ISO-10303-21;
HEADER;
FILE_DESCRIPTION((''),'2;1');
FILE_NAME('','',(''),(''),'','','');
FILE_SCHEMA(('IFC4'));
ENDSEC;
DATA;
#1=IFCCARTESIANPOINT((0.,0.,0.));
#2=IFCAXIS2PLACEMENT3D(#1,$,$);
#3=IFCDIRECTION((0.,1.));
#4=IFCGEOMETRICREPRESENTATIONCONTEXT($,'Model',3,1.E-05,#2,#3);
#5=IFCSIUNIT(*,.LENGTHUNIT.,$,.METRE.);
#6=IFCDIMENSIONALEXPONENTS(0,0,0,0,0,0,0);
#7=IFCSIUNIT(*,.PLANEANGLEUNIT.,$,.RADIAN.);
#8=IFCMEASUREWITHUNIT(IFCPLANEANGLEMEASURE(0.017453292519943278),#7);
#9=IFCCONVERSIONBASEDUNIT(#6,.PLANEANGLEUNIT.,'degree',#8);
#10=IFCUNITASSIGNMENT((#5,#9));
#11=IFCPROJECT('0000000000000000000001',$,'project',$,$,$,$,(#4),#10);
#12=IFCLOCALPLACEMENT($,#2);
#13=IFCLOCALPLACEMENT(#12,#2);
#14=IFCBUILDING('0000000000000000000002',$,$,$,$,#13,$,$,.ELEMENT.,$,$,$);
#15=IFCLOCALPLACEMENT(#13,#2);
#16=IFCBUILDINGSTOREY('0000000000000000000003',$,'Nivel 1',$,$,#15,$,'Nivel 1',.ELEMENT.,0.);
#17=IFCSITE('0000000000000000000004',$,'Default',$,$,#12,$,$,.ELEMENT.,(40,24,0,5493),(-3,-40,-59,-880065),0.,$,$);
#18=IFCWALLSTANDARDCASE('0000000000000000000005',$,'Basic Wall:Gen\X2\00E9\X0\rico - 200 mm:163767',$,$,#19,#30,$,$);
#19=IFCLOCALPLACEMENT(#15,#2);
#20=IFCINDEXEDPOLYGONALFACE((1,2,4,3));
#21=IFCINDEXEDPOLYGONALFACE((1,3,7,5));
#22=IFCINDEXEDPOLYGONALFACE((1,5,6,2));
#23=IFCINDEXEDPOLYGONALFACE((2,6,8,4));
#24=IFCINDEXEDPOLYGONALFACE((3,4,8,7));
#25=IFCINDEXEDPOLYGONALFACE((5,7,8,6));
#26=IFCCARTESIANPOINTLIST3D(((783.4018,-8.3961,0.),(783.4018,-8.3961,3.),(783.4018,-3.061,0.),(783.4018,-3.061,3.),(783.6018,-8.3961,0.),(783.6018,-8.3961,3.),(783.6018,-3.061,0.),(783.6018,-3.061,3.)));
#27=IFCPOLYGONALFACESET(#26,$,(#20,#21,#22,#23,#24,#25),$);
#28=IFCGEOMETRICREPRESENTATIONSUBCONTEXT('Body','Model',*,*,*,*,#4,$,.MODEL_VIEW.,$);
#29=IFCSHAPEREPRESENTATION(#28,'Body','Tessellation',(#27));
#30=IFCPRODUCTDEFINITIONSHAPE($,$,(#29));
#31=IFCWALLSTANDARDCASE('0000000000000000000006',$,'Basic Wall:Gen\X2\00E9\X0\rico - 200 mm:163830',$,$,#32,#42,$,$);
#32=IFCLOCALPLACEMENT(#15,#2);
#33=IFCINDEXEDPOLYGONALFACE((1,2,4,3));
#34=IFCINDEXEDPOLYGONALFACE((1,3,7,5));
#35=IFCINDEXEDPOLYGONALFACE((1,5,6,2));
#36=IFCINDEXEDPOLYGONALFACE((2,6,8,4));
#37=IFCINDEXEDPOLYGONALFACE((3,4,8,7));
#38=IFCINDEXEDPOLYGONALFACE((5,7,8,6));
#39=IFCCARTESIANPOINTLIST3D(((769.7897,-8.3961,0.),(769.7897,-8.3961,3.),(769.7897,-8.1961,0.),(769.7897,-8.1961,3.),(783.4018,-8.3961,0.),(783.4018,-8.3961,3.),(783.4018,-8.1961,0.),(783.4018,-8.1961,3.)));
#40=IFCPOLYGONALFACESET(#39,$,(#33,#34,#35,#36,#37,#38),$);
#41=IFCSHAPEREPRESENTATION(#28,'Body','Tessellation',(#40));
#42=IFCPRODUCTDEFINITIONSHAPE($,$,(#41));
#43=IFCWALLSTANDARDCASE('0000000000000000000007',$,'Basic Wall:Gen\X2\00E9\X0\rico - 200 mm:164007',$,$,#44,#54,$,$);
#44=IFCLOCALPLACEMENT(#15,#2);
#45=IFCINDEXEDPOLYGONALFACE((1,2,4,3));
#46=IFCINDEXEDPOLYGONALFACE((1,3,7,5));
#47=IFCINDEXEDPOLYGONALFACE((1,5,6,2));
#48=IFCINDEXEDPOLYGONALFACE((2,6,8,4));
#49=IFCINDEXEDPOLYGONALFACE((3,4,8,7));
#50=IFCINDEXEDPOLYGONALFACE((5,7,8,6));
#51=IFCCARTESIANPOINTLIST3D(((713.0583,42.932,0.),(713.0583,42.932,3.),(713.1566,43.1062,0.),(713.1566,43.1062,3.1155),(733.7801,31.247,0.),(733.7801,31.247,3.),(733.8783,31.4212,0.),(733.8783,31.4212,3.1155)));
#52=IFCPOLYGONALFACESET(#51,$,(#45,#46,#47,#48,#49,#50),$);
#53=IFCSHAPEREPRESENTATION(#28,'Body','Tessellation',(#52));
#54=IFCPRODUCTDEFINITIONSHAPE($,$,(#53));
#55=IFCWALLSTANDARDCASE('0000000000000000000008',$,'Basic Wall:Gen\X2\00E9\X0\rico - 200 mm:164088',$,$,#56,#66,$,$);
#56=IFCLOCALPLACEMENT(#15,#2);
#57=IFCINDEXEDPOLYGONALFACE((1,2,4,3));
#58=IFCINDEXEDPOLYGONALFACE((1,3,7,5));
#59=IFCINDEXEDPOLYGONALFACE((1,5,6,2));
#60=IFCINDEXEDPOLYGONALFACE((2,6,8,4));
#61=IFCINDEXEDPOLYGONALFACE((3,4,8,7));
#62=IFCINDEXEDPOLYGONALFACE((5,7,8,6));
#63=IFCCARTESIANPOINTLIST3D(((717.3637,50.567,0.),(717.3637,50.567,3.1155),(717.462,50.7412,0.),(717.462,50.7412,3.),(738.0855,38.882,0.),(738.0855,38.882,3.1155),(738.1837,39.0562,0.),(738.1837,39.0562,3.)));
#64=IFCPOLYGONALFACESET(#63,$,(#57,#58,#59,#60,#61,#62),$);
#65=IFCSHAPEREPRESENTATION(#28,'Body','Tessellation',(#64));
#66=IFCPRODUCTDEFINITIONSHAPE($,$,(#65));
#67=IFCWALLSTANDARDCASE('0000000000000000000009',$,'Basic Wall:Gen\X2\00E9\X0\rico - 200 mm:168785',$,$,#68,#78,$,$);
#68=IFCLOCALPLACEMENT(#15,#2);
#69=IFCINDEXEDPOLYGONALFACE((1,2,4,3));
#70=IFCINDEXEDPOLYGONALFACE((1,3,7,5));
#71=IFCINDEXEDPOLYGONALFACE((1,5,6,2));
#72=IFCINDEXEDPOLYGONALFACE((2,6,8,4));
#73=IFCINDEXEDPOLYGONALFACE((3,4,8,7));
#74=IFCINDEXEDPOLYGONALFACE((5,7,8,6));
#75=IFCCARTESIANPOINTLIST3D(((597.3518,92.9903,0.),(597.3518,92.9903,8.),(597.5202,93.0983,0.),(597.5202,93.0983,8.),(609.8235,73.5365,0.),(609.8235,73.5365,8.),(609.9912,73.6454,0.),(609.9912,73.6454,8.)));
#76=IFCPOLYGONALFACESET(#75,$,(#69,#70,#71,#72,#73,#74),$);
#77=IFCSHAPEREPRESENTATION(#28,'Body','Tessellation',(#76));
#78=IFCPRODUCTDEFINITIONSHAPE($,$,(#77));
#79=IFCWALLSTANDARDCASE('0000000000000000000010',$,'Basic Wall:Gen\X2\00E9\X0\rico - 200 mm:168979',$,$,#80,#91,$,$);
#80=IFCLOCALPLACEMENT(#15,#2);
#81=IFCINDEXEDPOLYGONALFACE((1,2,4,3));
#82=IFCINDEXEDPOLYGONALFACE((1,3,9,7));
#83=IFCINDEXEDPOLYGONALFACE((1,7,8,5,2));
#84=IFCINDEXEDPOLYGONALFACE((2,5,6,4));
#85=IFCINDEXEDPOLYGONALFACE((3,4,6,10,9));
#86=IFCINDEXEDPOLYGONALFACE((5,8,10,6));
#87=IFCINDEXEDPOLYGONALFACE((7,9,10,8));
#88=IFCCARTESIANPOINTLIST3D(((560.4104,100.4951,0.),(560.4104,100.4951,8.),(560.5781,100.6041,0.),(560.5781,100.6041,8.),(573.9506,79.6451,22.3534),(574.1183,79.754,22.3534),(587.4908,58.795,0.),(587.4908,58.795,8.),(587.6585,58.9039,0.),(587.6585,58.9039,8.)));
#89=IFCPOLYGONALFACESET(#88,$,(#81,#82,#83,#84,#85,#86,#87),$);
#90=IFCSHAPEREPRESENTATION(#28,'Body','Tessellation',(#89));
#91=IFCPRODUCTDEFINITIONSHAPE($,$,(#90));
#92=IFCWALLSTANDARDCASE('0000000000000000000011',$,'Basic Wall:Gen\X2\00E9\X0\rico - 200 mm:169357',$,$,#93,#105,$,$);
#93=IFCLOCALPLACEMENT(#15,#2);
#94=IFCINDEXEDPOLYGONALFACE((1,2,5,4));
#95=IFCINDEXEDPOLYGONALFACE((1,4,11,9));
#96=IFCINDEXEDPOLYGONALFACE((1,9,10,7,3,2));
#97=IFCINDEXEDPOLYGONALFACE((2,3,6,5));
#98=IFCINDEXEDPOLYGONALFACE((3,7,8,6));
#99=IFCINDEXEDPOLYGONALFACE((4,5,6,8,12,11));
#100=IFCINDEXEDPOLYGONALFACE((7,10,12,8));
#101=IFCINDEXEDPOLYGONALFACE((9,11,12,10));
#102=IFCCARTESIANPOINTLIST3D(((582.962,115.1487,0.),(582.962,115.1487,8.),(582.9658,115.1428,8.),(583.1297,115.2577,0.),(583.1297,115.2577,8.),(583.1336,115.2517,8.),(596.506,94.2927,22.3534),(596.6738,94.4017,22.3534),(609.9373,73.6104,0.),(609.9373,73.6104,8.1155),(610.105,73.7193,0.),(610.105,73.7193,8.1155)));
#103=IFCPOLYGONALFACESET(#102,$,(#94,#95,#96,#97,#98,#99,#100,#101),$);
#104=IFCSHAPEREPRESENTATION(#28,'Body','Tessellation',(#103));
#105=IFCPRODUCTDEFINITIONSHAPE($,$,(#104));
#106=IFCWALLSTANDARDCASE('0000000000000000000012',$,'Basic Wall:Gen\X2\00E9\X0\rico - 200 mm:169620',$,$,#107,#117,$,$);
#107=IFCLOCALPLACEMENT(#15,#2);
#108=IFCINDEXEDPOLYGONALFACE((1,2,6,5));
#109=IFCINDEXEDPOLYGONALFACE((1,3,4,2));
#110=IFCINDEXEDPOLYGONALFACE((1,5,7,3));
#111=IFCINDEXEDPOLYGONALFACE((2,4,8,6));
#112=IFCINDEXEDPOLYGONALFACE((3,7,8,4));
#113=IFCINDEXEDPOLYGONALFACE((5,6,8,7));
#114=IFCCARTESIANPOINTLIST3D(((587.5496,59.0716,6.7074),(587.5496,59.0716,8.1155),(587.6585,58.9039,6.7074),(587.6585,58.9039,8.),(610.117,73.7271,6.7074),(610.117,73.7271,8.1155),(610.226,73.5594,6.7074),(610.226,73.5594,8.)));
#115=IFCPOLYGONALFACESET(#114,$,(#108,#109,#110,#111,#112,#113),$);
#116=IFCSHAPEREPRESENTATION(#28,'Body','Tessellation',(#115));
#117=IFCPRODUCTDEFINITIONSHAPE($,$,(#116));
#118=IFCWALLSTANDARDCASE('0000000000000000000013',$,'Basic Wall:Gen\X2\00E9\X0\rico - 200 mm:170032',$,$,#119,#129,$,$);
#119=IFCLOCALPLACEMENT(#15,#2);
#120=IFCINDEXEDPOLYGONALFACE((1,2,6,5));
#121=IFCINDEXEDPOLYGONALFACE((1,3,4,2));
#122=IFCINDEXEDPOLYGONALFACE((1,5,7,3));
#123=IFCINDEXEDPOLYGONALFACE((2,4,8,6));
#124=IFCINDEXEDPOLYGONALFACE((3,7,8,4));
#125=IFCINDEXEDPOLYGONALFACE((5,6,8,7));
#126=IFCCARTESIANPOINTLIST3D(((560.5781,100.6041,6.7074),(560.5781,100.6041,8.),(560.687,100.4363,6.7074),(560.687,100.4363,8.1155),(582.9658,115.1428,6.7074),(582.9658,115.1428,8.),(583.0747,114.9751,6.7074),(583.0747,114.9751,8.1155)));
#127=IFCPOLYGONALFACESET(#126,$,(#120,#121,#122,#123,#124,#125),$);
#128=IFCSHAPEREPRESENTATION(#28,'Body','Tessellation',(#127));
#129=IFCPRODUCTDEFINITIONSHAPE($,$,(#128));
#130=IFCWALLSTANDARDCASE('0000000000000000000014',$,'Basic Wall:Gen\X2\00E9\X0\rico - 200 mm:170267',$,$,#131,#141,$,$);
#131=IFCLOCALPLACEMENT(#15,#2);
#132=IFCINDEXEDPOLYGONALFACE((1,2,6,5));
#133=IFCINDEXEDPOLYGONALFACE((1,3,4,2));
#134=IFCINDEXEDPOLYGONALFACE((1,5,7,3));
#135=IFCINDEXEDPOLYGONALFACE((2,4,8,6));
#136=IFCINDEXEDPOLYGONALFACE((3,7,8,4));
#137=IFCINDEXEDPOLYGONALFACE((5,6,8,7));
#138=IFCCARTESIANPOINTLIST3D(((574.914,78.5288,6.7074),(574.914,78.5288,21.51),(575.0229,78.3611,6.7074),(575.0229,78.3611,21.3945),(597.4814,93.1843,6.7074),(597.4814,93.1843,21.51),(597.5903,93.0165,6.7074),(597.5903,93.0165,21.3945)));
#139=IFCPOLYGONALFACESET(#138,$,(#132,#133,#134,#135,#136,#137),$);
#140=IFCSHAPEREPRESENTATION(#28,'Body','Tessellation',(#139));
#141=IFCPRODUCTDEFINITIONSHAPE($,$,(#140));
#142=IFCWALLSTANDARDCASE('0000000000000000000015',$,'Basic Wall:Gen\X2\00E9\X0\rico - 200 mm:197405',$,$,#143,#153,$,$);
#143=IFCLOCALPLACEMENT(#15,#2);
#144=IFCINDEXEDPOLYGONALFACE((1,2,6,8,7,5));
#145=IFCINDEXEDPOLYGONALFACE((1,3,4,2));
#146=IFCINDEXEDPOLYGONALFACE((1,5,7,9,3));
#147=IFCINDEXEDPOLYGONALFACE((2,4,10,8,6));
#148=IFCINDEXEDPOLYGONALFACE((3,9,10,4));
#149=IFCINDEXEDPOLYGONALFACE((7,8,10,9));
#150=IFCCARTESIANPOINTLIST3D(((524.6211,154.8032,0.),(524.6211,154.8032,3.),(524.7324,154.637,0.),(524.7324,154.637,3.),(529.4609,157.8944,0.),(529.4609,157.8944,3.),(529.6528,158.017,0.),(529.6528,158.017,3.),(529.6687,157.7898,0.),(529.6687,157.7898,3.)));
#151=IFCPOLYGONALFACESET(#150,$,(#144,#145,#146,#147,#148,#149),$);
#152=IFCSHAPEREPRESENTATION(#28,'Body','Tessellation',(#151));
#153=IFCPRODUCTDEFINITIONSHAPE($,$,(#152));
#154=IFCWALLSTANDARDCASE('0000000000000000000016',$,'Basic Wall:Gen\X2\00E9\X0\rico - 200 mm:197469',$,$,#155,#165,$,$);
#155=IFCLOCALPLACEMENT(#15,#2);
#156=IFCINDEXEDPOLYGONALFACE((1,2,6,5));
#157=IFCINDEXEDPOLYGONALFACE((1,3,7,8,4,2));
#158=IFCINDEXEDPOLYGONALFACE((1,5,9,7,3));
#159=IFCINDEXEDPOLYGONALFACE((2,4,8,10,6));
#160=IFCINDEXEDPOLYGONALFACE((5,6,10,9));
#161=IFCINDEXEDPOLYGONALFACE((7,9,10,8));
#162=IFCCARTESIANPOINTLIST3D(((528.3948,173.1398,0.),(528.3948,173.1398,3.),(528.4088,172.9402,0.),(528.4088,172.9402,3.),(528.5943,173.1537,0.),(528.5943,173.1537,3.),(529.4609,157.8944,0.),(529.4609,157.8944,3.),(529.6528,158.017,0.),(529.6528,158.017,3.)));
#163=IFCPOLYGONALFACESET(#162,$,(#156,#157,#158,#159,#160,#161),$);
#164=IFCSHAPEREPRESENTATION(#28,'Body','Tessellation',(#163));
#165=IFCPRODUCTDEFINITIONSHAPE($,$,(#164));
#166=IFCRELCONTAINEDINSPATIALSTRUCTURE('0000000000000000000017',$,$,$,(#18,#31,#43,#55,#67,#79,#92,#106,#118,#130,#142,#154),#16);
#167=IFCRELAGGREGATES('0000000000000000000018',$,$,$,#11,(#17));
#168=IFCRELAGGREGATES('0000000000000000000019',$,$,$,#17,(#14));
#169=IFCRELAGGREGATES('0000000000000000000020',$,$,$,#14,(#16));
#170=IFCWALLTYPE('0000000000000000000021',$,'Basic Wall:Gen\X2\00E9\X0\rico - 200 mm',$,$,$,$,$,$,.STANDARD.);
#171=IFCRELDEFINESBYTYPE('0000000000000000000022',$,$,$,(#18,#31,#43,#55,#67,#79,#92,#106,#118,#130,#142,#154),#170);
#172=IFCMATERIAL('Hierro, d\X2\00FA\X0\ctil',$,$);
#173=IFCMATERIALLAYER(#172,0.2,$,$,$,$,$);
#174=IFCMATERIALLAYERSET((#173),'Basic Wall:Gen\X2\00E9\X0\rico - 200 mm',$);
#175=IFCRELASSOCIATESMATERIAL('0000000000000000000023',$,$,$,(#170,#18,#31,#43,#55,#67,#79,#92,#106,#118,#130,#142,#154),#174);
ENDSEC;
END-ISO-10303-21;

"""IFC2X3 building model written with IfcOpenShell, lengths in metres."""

from ifc_helpers import new_model, entity, si_unit, converted_unit, direction, frame, frame_2d, origin, place, context, subcontext, project, spatial, polyline, rectangle, outline, extrude, clip, bounded_halfspace, material, layer, layer_set, layer_usage, type_object, element, save


model = new_model("IFC2X3")

# Units and contexts
model_context = context("Model", 3, precision=1e-05, world=origin(), true_north=direction((0.0, 1.0)))
body_context = subcontext(model_context, "Body", "Model", "MODEL_VIEW")
ifc_project = project(units=[si_unit("LENGTHUNIT", "METRE"), converted_unit("PLANEANGLEUNIT", "degree", entity("IfcPlaneAngleMeasure", 0.017453292519943278), si_unit("PLANEANGLEUNIT", "RADIAN"), dimensions=[0, 0, 0, 0, 0, 0, 0])], contexts=[model_context])

# Site, building, storey
site_placement = place(None, origin())
site = spatial("IfcSite", under=ifc_project, at=site_placement, Name="Default", CompositionType="ELEMENT", RefLatitude=(40, 24, 0, 5493), RefLongitude=(-3, -40, -59, -880065), RefElevation=0.0)
building_placement = place(site_placement, origin())
building = spatial("IfcBuilding", under=site, at=building_placement, CompositionType="ELEMENT")
storey_placement = place(building_placement, origin())
storey = spatial("IfcBuildingStorey", under=building, at=storey_placement, Name="Nivel 1", LongName="Nivel 1", CompositionType="ELEMENT", Elevation=0.0)

# Walls
ifc_material_1 = material(Name="Hierro, dúctil")
ifc_layer_1 = layer(ifc_material_1, 0.2)
ifc_layer_set_1 = layer_set([ifc_layer_1], Name="Basic Wall:Genérico - 200 mm")
wall_type = type_object("IfcWallType", Name="Basic Wall:Genérico - 200 mm", PredefinedType="STANDARD", material=ifc_layer_set_1)
ifc_layer_usage_1 = layer_usage(ifc_layer_set_1, "AXIS2", "NEGATIVE", 0.1)
wall_1_placement = place(storey_placement, frame((783.5018, -3.061, 0.0), z_axis=(0.0, 0.0, 1.0), x_axis=(0.0, -1.0, 0.0)))
element("IfcWallStandardCase", 1, at=wall_1_placement, inside=storey, type_object=wall_type, material=ifc_layer_usage_1, Name="Basic Wall:Genérico - 200 mm:163767", context=body_context, shape_type="SweptSolid", body=[
    extrude(rectangle(XDim=5.3351, YDim=0.2, at=frame_2d((2.6675, 0.0), x_axis=(-1.0, 0.0))), origin(), (0.0, 0.0, 1.0), 3.0),
])
ifc_layer_usage_2 = layer_usage(ifc_layer_set_1, "AXIS2", "NEGATIVE", 0.1)
wall_2_placement = place(storey_placement, frame((783.4018, -8.2961, 0.0), z_axis=(0.0, 0.0, 1.0), x_axis=(-1.0, 0.0, 0.0)))
element("IfcWallStandardCase", 2, at=wall_2_placement, inside=storey, type_object=wall_type, material=ifc_layer_usage_2, Name="Basic Wall:Genérico - 200 mm:163830", context=body_context, shape_type="SweptSolid", body=[
    extrude(rectangle(XDim=13.6122, YDim=0.2, at=frame_2d((6.8061, 0.0), x_axis=(-1.0, 0.0))), origin(), (0.0, 0.0, 1.0), 3.0),
])
ifc_layer_usage_3 = layer_usage(ifc_layer_set_1, "AXIS2", "NEGATIVE", 0.1)
wall_3_placement = place(storey_placement, frame((713.1075, 43.0191, 0.0), z_axis=(0.0, 0.0, 1.0), x_axis=(0.871054, -0.491187, 0.0)))
element("IfcWallStandardCase", 3, at=wall_3_placement, inside=storey, type_object=wall_type, material=ifc_layer_usage_3, Name="Basic Wall:Genérico - 200 mm:164007", context=body_context, shape_type="Clipping", body=[
    clip(extrude(rectangle(XDim=23.7893, YDim=0.2, at=frame_2d((11.8946, 0.0), x_axis=(-1.0, 0.0))), origin(), (0.0, 0.0, 1.0), 3.1155), bounded_halfspace(frame((0.0, -0.1, 3.0), z_axis=(0.0, -0.5, 0.866025), x_axis=(1.0, 0.0, 0.0)), False, frame((0.0, -0.1, 3.0)), polyline([(0.0, 0.0), (23.7893, 0.0), (23.7893, 0.2), (23.5893, 0.2), (0.2, 0.2), (0.0, 0.2), (0.0, 0.0)]))),
])
ifc_layer_usage_4 = layer_usage(ifc_layer_set_1, "AXIS2", "NEGATIVE", 0.1)
wall_4_placement = place(storey_placement, frame((738.1346, 38.9691, 0.0), z_axis=(0.0, 0.0, 1.0), x_axis=(-0.871054, 0.491187, 0.0)))
element("IfcWallStandardCase", 4, at=wall_4_placement, inside=storey, type_object=wall_type, material=ifc_layer_usage_4, Name="Basic Wall:Genérico - 200 mm:164088", context=body_context, shape_type="Clipping", body=[
    clip(extrude(rectangle(XDim=23.7893, YDim=0.2, at=frame_2d((11.8946, 0.0), x_axis=(-1.0, 0.0))), origin(), (0.0, 0.0, 1.0), 3.1155), bounded_halfspace(frame((0.0, -0.1, 3.0), z_axis=(0.0, -0.5, 0.866025), x_axis=(1.0, 0.0, 0.0)), False, frame((0.0, -0.1, 3.0)), polyline([(0.0, 0.0), (23.7893, 0.0), (23.7893, 0.2), (23.5893, 0.2), (0.2, 0.2), (0.0, 0.2), (0.0, 0.0)]))),
])
ifc_layer_usage_5 = layer_usage(ifc_layer_set_1, "AXIS2", "NEGATIVE", 0.1)
wall_5_placement = place(storey_placement, frame((597.436, 93.0443, 0.0), z_axis=(0.0, 0.0, 1.0), x_axis=(0.539704, -0.841855, 0.0)))
element("IfcWallStandardCase", 5, at=wall_5_placement, inside=storey, type_object=wall_type, material=ifc_layer_usage_5, Name="Basic Wall:Genérico - 200 mm:168785", context=body_context, shape_type="SweptSolid", body=[
    extrude(outline(polyline([(23.1083, -0.1), (23.1072, 0.1), (0.0, 0.1), (0.0, -0.1), (23.1083, -0.1)])), origin(), (0.0, 0.0, 1.0), 8.0),
])
ifc_layer_usage_6 = layer_usage(ifc_layer_set_1, "AXIS2", "NEGATIVE", 0.1)
wall_6_placement = place(storey_placement, frame((560.4942, 100.5496, 0.0), z_axis=(0.0, 0.0, 1.0), x_axis=(0.544639, -0.838671, 0.0)))
element("IfcWallStandardCase", 6, at=wall_6_placement, inside=storey, type_object=wall_type, material=ifc_layer_usage_6, Name="Basic Wall:Genérico - 200 mm:168979", context=body_context, shape_type="Clipping", body=[
    clip(clip(extrude(rectangle(XDim=49.7218, YDim=0.2, at=frame_2d((24.8609, 0.0), x_axis=(-1.0, 0.0))), origin(), (0.0, 0.0, 1.0), 22.3534), bounded_halfspace(frame((0.0, -0.1, 8.0), z_axis=(-0.5, 0.0, 0.866025), x_axis=(0.0, -1.0, 0.0)), False, frame((0.0, -0.1, 8.0)), polyline([(0.0, 0.0), (24.8609, 0.0), (24.8609, 0.2), (0.2, 0.2), (0.0, 0.2), (0.0, 0.0)]))), bounded_halfspace(frame((24.8609, -0.1, 22.3534), z_axis=(0.5, 0.0, 0.866025), x_axis=(0.0, 1.0, 0.0)), False, frame((24.8609, -0.1, 22.3534)), polyline([(0.0, 0.0), (24.8609, 0.0), (24.8609, 0.2), (24.6609, 0.2), (1.6609, 0.2), (1.4609, 0.2), (0.0, 0.2), (0.0, 0.0)]))),
])
ifc_layer_usage_7 = layer_usage(ifc_layer_set_1, "AXIS2", "NEGATIVE", 0.1)
wall_7_placement = place(storey_placement, frame((583.0458, 115.2032, 0.0), z_axis=(0.0, 0.0, 1.0), x_axis=(0.544639, -0.838671, 0.0)))
element("IfcWallStandardCase", 7, at=wall_7_placement, inside=storey, type_object=wall_type, material=ifc_layer_usage_7, Name="Basic Wall:Genérico - 200 mm:169357", context=body_context, shape_type="Clipping", body=[
    clip(clip(clip(extrude(rectangle(XDim=49.5288, YDim=0.2, at=frame_2d((24.7644, 0.0), x_axis=(-1.0, 0.0))), origin(), (0.0, 0.0, 1.0), 22.3534), bounded_halfspace(frame((0.0071, -0.1, 8.0), z_axis=(-0.5, 0.0, 0.866025), x_axis=(0.0, -1.0, 0.0)), False, frame((0.0071, -0.1, 8.0)), polyline([(0.0, 0.0), (0.2, 0.0), (24.8609, 0.0), (24.8609, 0.2), (0.0, 0.2), (0.0, 0.0)]))), bounded_halfspace(frame((24.8679, -0.1, 22.3534), z_axis=(0.5, 0.0, 0.866025), x_axis=(0.0, 1.0, 0.0)), False, frame((24.8679, -0.1, 22.3534)), polyline([(0.0, 0.0), (24.6609, 0.0), (24.6609, 0.2), (0.0, 0.2), (0.0, 0.0)]))), bounded_halfspace(frame((0.0, -0.1, 8.0), z_axis=(0.0, 0.0, 1.0), x_axis=(0.0, 1.0, 0.0)), False, frame((0.0, -0.1, 8.0)), polyline([(0.0, 0.0), (0.0071, 0.0), (0.0071, 0.2), (0.0, 0.2), (0.0, 0.0)]))),
])
ifc_layer_usage_8 = layer_usage(ifc_layer_set_1, "AXIS2", "NEGATIVE", 0.1)
wall_8_placement = place(storey_placement, frame((587.6041, 58.9878, 6.7074), z_axis=(0.0, 0.0, 1.0), x_axis=(0.838671, 0.544639, 0.0)))
element("IfcWallStandardCase", 8, at=wall_8_placement, inside=storey, type_object=wall_type, material=ifc_layer_usage_8, Name="Basic Wall:Genérico - 200 mm:169620", context=body_context, shape_type="Clipping", body=[
    clip(extrude(rectangle(XDim=26.9086, YDim=0.2, at=frame_2d((13.4543, 0.0), x_axis=(-1.0, 0.0))), origin(), (0.0, 0.0, 1.0), 1.408), bounded_halfspace(frame((0.0, -0.1, 1.2926), z_axis=(0.0, -0.5, 0.866025), x_axis=(1.0, 0.0, 0.0)), False, frame((0.0, -0.1, 1.2926)), polyline([(0.0, 0.0), (26.9086, 0.0), (26.9086, 0.2), (26.8943, 0.2), (26.6943, 0.2), (0.0, 0.2), (0.0, 0.0)]))),
])
ifc_layer_usage_9 = layer_usage(ifc_layer_set_1, "AXIS2", "NEGATIVE", 0.1)
wall_9_placement = place(storey_placement, frame((560.6326, 100.5202, 6.7074), z_axis=(0.0, 0.0, 1.0), x_axis=(0.838671, 0.544639, 0.0)))
element("IfcWallStandardCase", 9, at=wall_9_placement, inside=storey, type_object=wall_type, material=ifc_layer_usage_9, Name="Basic Wall:Genérico - 200 mm:170032", context=body_context, shape_type="Clipping", body=[
    clip(extrude(rectangle(XDim=26.6943, YDim=0.2, at=frame_2d((13.3471, 0.0), x_axis=(-1.0, 0.0))), origin(), (0.0, 0.0, 1.0), 1.408), bounded_halfspace(frame((0.0, -0.1, 1.408), z_axis=(0.0, 0.5, 0.866025), x_axis=(-1.0, 0.0, 0.0)), False, frame((0.0, -0.1, 1.408)), polyline([(0.0, 0.0), (26.6943, 0.0), (26.6943, 0.2), (0.0, 0.2), (0.0, 0.0)]))),
])
ifc_layer_usage_10 = layer_usage(ifc_layer_set_1, "AXIS2", "NEGATIVE", 0.1)
wall_10_placement = place(storey_placement, frame((574.9684, 78.4449, 6.7074), z_axis=(0.0, 0.0, 1.0), x_axis=(0.838671, 0.544639, 0.0)))
element("IfcWallStandardCase", 10, at=wall_10_placement, inside=storey, type_object=wall_type, material=ifc_layer_usage_10, Name="Basic Wall:Genérico - 200 mm:170267", context=body_context, shape_type="Clipping", body=[
    clip(extrude(rectangle(XDim=26.9086, YDim=0.2, at=frame_2d((13.4543, 0.0), x_axis=(-1.0, 0.0))), origin(), (0.0, 0.0, 1.0), 14.8026), bounded_halfspace(frame((0.0, -0.1, 14.6871), z_axis=(0.0, -0.5, 0.866025), x_axis=(1.0, 0.0, 0.0)), False, frame((0.0, -0.1, 14.6871)), polyline([(0.0, 0.0), (26.9086, 0.0), (26.9086, 0.2), (0.0, 0.2), (0.0, 0.0)]))),
])
ifc_layer_usage_11 = layer_usage(ifc_layer_set_1, "AXIS2", "NEGATIVE", 0.1)
wall_11_placement = place(storey_placement, frame((524.6749, 154.7189, 0.0), z_axis=(0.0, 0.0, 1.0), x_axis=(0.842768, 0.538277, 0.0)))
element("IfcWallStandardCase", 11, at=wall_11_placement, inside=storey, type_object=wall_type, material=ifc_layer_usage_11, Name="Basic Wall:Genérico - 200 mm:197405", context=body_context, shape_type="SweptSolid", body=[
    extrude(outline(polyline([(5.8616, -0.1), (5.9705, 0.1), (5.7428, 0.1), (0.0, 0.1), (0.0044, -0.1), (5.8616, -0.1)])), origin(), (0.0, 0.0, 1.0), 3.0),
])
ifc_layer_usage_12 = layer_usage(ifc_layer_set_1, "AXIS2", "NEGATIVE", 0.1)
wall_12_placement = place(storey_placement, frame((529.5606, 157.9014, 0.0), z_axis=(0.0, 0.0, 1.0), x_axis=(-0.069756, 0.997564, 0.0)))
element("IfcWallStandardCase", 12, at=wall_12_placement, inside=storey, type_object=wall_type, material=ifc_layer_usage_12, Name="Basic Wall:Genérico - 200 mm:197469", context=body_context, shape_type="SweptSolid", body=[
    extrude(outline(polyline([(15.2826, -0.1), (15.2826, 0.1), (15.0826, 0.1), (0.0, 0.1), (0.1089, -0.1), (15.2826, -0.1)])), origin(), (0.0, 0.0, 1.0), 3.0),
])

save(model, "model.ifc")
